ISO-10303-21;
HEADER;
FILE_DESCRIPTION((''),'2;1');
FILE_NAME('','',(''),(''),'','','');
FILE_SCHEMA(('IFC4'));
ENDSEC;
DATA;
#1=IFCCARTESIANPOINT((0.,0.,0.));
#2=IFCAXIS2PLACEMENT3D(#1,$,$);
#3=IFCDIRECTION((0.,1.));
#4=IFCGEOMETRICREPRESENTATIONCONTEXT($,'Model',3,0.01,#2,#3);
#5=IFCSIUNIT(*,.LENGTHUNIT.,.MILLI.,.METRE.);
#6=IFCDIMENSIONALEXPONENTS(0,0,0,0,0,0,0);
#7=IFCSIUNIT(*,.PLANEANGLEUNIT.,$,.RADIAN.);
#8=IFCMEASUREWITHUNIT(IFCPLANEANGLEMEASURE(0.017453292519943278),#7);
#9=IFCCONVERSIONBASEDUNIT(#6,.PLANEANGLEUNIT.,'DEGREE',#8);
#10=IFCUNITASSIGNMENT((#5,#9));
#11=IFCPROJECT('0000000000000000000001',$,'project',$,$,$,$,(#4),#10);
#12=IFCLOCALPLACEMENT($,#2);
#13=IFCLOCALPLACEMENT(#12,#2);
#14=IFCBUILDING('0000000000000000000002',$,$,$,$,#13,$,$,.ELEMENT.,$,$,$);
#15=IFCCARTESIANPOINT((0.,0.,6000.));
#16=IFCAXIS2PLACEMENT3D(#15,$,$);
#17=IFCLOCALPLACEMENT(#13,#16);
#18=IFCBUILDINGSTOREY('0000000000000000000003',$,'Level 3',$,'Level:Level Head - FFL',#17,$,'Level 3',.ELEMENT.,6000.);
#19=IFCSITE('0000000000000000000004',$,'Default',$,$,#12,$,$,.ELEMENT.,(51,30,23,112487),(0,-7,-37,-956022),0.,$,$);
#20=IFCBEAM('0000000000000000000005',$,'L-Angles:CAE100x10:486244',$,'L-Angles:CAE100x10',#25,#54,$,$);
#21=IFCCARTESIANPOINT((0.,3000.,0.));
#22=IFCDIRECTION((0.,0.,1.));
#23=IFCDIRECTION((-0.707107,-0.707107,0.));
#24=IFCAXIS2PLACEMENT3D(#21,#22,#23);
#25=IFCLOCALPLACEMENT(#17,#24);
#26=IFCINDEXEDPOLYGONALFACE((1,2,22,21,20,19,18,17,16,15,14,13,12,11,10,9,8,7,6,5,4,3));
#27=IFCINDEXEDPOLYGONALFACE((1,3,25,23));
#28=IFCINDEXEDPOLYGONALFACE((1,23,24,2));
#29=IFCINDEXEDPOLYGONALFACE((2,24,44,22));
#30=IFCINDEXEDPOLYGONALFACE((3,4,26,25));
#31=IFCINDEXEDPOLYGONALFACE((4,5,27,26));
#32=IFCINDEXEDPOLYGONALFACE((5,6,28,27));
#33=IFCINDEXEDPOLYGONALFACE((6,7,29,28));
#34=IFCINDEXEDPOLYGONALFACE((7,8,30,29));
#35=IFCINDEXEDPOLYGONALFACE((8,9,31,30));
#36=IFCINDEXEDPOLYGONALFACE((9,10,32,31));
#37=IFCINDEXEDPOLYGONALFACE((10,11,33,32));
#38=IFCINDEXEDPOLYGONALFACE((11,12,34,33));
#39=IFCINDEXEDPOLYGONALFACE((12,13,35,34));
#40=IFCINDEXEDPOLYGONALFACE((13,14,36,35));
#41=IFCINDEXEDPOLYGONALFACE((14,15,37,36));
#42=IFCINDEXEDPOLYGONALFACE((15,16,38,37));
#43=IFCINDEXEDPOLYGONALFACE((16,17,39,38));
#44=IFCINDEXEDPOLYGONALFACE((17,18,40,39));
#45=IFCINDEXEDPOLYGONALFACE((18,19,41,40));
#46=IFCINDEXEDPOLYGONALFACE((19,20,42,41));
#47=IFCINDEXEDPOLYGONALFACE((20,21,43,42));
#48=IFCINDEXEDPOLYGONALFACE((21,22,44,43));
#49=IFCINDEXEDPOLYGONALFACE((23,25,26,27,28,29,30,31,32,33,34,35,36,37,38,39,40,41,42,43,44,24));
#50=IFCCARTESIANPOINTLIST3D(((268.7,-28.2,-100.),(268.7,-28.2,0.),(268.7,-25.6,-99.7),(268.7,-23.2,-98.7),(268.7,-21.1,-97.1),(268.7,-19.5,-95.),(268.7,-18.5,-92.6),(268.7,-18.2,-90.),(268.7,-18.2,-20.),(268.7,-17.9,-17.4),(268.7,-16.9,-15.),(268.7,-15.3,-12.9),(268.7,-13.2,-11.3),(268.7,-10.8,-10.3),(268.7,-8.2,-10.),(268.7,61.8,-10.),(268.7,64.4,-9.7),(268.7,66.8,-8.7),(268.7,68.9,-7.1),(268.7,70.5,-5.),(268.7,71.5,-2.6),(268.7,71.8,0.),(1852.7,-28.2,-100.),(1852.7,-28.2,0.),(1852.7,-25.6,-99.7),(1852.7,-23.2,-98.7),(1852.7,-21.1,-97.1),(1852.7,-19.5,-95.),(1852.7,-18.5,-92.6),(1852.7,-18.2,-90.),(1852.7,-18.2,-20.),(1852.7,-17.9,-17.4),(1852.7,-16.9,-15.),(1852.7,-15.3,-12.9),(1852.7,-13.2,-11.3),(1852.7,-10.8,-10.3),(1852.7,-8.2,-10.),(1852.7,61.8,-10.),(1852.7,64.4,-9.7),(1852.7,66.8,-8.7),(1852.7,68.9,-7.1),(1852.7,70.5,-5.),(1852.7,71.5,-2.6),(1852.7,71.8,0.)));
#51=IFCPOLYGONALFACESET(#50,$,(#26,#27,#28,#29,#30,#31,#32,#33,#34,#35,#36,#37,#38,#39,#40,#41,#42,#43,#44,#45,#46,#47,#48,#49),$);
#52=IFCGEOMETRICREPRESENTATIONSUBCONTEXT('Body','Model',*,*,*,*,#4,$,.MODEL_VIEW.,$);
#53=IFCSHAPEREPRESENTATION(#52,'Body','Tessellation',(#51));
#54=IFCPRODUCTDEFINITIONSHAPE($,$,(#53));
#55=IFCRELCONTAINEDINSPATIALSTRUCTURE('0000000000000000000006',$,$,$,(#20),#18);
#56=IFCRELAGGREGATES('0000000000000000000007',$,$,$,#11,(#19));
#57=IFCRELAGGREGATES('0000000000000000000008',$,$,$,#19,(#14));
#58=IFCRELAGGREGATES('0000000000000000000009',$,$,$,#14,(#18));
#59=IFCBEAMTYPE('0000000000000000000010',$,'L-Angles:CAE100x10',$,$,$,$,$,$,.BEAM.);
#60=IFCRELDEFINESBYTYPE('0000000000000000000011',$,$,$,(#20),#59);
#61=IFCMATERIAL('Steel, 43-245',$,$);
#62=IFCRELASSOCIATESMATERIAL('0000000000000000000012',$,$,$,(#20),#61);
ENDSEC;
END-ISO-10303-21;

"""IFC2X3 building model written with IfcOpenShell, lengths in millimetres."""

from ifc_helpers import new_model, entity, si_unit, converted_unit, direction, frame, frame_2d, origin, place, context, subcontext, project, spatial, polyline, circle_curve, parameter, trimmed, segment, composite_curve, outline, extrude, material, type_object, element, save


model = new_model("IFC2X3")

# Units and contexts
model_context = context("Model", 3, precision=0.01, world=origin(), true_north=direction((0.0, 1.0)))
body_context = subcontext(model_context, "Body", "Model", "MODEL_VIEW")
ifc_project = project(units=[si_unit("LENGTHUNIT", "METRE", prefix="MILLI"), converted_unit("PLANEANGLEUNIT", "DEGREE", entity("IfcPlaneAngleMeasure", 0.017453292519943278), si_unit("PLANEANGLEUNIT", "RADIAN"), dimensions=[0, 0, 0, 0, 0, 0, 0])], contexts=[model_context])

# Site, building, storey
site_placement = place(None, origin())
site = spatial("IfcSite", under=ifc_project, at=site_placement, Name="Default", CompositionType="ELEMENT", RefLatitude=(51, 30, 23, 112487), RefLongitude=(0, -7, -37, -956022), RefElevation=0.0)
building_placement = place(site_placement, origin())
building = spatial("IfcBuilding", under=site, at=building_placement, CompositionType="ELEMENT")
storey_placement = place(building_placement, frame((0.0, 0.0, 6000.0)))
storey = spatial("IfcBuildingStorey", under=building, at=storey_placement, Name="Level 3", ObjectType="Level:Level Head - FFL", LongName="Level 3", CompositionType="ELEMENT", Elevation=6000.0)

# Beam
ifc_material = material(Name="Steel, 43-245")
beam_type_1 = type_object("IfcBeamType", Name="L-Angles:CAE100x10", PredefinedType="BEAM")
beam_1_placement = place(storey_placement, frame((0.0, 3000.0, 0.0), z_axis=(0.0, 0.0, 1.0), x_axis=(-0.707107, -0.707107, 0.0)))
element("IfcBeam", 1, at=beam_1_placement, inside=storey, type_object=beam_type_1, material=ifc_material, Name="L-Angles:CAE100x10:486244", ObjectType="L-Angles:CAE100x10", context=body_context, shape_type="SweptSolid", body=[
    extrude(outline(composite_curve([segment(polyline([(-32.9, -32.9), (67.1, -32.9)]), True, "CONTINUOUS"), segment(trimmed(circle_curve(frame_2d((57.1, -32.9), x_axis=(1.0, 0.0)), 10.0), [parameter(0.0)], [parameter(90.0)], True, "PARAMETER"), True, "CONTINUOUS"), segment(polyline([(57.1, -22.9), (-12.9, -22.9)]), True, "CONTINUOUS"), segment(trimmed(circle_curve(frame_2d((-12.9, -12.9), x_axis=(0.0, -1.0)), 10.0), [parameter(270.0)], [parameter(0.0)], True, "PARAMETER"), False, "CONTINUOUS"), segment(polyline([(-22.9, -12.9), (-22.9, 57.1)]), True, "CONTINUOUS"), segment(trimmed(circle_curve(frame_2d((-32.9, 57.1), x_axis=(1.0, 0.0)), 10.0), [parameter(0.0)], [parameter(90.0)], True, "PARAMETER"), True, "CONTINUOUS"), segment(polyline([(-32.9, 67.1), (-32.9, -32.9)]), True, "CONTINUOUS")], self_intersect=False)), frame((268.7, 4.7, -32.9), z_axis=(1.0, 0.0, 0.0), x_axis=(0.0, 0.0, -1.0)), (0.0, 0.0, 1.0), 1584.0),
])

save(model, "model.ifc")
